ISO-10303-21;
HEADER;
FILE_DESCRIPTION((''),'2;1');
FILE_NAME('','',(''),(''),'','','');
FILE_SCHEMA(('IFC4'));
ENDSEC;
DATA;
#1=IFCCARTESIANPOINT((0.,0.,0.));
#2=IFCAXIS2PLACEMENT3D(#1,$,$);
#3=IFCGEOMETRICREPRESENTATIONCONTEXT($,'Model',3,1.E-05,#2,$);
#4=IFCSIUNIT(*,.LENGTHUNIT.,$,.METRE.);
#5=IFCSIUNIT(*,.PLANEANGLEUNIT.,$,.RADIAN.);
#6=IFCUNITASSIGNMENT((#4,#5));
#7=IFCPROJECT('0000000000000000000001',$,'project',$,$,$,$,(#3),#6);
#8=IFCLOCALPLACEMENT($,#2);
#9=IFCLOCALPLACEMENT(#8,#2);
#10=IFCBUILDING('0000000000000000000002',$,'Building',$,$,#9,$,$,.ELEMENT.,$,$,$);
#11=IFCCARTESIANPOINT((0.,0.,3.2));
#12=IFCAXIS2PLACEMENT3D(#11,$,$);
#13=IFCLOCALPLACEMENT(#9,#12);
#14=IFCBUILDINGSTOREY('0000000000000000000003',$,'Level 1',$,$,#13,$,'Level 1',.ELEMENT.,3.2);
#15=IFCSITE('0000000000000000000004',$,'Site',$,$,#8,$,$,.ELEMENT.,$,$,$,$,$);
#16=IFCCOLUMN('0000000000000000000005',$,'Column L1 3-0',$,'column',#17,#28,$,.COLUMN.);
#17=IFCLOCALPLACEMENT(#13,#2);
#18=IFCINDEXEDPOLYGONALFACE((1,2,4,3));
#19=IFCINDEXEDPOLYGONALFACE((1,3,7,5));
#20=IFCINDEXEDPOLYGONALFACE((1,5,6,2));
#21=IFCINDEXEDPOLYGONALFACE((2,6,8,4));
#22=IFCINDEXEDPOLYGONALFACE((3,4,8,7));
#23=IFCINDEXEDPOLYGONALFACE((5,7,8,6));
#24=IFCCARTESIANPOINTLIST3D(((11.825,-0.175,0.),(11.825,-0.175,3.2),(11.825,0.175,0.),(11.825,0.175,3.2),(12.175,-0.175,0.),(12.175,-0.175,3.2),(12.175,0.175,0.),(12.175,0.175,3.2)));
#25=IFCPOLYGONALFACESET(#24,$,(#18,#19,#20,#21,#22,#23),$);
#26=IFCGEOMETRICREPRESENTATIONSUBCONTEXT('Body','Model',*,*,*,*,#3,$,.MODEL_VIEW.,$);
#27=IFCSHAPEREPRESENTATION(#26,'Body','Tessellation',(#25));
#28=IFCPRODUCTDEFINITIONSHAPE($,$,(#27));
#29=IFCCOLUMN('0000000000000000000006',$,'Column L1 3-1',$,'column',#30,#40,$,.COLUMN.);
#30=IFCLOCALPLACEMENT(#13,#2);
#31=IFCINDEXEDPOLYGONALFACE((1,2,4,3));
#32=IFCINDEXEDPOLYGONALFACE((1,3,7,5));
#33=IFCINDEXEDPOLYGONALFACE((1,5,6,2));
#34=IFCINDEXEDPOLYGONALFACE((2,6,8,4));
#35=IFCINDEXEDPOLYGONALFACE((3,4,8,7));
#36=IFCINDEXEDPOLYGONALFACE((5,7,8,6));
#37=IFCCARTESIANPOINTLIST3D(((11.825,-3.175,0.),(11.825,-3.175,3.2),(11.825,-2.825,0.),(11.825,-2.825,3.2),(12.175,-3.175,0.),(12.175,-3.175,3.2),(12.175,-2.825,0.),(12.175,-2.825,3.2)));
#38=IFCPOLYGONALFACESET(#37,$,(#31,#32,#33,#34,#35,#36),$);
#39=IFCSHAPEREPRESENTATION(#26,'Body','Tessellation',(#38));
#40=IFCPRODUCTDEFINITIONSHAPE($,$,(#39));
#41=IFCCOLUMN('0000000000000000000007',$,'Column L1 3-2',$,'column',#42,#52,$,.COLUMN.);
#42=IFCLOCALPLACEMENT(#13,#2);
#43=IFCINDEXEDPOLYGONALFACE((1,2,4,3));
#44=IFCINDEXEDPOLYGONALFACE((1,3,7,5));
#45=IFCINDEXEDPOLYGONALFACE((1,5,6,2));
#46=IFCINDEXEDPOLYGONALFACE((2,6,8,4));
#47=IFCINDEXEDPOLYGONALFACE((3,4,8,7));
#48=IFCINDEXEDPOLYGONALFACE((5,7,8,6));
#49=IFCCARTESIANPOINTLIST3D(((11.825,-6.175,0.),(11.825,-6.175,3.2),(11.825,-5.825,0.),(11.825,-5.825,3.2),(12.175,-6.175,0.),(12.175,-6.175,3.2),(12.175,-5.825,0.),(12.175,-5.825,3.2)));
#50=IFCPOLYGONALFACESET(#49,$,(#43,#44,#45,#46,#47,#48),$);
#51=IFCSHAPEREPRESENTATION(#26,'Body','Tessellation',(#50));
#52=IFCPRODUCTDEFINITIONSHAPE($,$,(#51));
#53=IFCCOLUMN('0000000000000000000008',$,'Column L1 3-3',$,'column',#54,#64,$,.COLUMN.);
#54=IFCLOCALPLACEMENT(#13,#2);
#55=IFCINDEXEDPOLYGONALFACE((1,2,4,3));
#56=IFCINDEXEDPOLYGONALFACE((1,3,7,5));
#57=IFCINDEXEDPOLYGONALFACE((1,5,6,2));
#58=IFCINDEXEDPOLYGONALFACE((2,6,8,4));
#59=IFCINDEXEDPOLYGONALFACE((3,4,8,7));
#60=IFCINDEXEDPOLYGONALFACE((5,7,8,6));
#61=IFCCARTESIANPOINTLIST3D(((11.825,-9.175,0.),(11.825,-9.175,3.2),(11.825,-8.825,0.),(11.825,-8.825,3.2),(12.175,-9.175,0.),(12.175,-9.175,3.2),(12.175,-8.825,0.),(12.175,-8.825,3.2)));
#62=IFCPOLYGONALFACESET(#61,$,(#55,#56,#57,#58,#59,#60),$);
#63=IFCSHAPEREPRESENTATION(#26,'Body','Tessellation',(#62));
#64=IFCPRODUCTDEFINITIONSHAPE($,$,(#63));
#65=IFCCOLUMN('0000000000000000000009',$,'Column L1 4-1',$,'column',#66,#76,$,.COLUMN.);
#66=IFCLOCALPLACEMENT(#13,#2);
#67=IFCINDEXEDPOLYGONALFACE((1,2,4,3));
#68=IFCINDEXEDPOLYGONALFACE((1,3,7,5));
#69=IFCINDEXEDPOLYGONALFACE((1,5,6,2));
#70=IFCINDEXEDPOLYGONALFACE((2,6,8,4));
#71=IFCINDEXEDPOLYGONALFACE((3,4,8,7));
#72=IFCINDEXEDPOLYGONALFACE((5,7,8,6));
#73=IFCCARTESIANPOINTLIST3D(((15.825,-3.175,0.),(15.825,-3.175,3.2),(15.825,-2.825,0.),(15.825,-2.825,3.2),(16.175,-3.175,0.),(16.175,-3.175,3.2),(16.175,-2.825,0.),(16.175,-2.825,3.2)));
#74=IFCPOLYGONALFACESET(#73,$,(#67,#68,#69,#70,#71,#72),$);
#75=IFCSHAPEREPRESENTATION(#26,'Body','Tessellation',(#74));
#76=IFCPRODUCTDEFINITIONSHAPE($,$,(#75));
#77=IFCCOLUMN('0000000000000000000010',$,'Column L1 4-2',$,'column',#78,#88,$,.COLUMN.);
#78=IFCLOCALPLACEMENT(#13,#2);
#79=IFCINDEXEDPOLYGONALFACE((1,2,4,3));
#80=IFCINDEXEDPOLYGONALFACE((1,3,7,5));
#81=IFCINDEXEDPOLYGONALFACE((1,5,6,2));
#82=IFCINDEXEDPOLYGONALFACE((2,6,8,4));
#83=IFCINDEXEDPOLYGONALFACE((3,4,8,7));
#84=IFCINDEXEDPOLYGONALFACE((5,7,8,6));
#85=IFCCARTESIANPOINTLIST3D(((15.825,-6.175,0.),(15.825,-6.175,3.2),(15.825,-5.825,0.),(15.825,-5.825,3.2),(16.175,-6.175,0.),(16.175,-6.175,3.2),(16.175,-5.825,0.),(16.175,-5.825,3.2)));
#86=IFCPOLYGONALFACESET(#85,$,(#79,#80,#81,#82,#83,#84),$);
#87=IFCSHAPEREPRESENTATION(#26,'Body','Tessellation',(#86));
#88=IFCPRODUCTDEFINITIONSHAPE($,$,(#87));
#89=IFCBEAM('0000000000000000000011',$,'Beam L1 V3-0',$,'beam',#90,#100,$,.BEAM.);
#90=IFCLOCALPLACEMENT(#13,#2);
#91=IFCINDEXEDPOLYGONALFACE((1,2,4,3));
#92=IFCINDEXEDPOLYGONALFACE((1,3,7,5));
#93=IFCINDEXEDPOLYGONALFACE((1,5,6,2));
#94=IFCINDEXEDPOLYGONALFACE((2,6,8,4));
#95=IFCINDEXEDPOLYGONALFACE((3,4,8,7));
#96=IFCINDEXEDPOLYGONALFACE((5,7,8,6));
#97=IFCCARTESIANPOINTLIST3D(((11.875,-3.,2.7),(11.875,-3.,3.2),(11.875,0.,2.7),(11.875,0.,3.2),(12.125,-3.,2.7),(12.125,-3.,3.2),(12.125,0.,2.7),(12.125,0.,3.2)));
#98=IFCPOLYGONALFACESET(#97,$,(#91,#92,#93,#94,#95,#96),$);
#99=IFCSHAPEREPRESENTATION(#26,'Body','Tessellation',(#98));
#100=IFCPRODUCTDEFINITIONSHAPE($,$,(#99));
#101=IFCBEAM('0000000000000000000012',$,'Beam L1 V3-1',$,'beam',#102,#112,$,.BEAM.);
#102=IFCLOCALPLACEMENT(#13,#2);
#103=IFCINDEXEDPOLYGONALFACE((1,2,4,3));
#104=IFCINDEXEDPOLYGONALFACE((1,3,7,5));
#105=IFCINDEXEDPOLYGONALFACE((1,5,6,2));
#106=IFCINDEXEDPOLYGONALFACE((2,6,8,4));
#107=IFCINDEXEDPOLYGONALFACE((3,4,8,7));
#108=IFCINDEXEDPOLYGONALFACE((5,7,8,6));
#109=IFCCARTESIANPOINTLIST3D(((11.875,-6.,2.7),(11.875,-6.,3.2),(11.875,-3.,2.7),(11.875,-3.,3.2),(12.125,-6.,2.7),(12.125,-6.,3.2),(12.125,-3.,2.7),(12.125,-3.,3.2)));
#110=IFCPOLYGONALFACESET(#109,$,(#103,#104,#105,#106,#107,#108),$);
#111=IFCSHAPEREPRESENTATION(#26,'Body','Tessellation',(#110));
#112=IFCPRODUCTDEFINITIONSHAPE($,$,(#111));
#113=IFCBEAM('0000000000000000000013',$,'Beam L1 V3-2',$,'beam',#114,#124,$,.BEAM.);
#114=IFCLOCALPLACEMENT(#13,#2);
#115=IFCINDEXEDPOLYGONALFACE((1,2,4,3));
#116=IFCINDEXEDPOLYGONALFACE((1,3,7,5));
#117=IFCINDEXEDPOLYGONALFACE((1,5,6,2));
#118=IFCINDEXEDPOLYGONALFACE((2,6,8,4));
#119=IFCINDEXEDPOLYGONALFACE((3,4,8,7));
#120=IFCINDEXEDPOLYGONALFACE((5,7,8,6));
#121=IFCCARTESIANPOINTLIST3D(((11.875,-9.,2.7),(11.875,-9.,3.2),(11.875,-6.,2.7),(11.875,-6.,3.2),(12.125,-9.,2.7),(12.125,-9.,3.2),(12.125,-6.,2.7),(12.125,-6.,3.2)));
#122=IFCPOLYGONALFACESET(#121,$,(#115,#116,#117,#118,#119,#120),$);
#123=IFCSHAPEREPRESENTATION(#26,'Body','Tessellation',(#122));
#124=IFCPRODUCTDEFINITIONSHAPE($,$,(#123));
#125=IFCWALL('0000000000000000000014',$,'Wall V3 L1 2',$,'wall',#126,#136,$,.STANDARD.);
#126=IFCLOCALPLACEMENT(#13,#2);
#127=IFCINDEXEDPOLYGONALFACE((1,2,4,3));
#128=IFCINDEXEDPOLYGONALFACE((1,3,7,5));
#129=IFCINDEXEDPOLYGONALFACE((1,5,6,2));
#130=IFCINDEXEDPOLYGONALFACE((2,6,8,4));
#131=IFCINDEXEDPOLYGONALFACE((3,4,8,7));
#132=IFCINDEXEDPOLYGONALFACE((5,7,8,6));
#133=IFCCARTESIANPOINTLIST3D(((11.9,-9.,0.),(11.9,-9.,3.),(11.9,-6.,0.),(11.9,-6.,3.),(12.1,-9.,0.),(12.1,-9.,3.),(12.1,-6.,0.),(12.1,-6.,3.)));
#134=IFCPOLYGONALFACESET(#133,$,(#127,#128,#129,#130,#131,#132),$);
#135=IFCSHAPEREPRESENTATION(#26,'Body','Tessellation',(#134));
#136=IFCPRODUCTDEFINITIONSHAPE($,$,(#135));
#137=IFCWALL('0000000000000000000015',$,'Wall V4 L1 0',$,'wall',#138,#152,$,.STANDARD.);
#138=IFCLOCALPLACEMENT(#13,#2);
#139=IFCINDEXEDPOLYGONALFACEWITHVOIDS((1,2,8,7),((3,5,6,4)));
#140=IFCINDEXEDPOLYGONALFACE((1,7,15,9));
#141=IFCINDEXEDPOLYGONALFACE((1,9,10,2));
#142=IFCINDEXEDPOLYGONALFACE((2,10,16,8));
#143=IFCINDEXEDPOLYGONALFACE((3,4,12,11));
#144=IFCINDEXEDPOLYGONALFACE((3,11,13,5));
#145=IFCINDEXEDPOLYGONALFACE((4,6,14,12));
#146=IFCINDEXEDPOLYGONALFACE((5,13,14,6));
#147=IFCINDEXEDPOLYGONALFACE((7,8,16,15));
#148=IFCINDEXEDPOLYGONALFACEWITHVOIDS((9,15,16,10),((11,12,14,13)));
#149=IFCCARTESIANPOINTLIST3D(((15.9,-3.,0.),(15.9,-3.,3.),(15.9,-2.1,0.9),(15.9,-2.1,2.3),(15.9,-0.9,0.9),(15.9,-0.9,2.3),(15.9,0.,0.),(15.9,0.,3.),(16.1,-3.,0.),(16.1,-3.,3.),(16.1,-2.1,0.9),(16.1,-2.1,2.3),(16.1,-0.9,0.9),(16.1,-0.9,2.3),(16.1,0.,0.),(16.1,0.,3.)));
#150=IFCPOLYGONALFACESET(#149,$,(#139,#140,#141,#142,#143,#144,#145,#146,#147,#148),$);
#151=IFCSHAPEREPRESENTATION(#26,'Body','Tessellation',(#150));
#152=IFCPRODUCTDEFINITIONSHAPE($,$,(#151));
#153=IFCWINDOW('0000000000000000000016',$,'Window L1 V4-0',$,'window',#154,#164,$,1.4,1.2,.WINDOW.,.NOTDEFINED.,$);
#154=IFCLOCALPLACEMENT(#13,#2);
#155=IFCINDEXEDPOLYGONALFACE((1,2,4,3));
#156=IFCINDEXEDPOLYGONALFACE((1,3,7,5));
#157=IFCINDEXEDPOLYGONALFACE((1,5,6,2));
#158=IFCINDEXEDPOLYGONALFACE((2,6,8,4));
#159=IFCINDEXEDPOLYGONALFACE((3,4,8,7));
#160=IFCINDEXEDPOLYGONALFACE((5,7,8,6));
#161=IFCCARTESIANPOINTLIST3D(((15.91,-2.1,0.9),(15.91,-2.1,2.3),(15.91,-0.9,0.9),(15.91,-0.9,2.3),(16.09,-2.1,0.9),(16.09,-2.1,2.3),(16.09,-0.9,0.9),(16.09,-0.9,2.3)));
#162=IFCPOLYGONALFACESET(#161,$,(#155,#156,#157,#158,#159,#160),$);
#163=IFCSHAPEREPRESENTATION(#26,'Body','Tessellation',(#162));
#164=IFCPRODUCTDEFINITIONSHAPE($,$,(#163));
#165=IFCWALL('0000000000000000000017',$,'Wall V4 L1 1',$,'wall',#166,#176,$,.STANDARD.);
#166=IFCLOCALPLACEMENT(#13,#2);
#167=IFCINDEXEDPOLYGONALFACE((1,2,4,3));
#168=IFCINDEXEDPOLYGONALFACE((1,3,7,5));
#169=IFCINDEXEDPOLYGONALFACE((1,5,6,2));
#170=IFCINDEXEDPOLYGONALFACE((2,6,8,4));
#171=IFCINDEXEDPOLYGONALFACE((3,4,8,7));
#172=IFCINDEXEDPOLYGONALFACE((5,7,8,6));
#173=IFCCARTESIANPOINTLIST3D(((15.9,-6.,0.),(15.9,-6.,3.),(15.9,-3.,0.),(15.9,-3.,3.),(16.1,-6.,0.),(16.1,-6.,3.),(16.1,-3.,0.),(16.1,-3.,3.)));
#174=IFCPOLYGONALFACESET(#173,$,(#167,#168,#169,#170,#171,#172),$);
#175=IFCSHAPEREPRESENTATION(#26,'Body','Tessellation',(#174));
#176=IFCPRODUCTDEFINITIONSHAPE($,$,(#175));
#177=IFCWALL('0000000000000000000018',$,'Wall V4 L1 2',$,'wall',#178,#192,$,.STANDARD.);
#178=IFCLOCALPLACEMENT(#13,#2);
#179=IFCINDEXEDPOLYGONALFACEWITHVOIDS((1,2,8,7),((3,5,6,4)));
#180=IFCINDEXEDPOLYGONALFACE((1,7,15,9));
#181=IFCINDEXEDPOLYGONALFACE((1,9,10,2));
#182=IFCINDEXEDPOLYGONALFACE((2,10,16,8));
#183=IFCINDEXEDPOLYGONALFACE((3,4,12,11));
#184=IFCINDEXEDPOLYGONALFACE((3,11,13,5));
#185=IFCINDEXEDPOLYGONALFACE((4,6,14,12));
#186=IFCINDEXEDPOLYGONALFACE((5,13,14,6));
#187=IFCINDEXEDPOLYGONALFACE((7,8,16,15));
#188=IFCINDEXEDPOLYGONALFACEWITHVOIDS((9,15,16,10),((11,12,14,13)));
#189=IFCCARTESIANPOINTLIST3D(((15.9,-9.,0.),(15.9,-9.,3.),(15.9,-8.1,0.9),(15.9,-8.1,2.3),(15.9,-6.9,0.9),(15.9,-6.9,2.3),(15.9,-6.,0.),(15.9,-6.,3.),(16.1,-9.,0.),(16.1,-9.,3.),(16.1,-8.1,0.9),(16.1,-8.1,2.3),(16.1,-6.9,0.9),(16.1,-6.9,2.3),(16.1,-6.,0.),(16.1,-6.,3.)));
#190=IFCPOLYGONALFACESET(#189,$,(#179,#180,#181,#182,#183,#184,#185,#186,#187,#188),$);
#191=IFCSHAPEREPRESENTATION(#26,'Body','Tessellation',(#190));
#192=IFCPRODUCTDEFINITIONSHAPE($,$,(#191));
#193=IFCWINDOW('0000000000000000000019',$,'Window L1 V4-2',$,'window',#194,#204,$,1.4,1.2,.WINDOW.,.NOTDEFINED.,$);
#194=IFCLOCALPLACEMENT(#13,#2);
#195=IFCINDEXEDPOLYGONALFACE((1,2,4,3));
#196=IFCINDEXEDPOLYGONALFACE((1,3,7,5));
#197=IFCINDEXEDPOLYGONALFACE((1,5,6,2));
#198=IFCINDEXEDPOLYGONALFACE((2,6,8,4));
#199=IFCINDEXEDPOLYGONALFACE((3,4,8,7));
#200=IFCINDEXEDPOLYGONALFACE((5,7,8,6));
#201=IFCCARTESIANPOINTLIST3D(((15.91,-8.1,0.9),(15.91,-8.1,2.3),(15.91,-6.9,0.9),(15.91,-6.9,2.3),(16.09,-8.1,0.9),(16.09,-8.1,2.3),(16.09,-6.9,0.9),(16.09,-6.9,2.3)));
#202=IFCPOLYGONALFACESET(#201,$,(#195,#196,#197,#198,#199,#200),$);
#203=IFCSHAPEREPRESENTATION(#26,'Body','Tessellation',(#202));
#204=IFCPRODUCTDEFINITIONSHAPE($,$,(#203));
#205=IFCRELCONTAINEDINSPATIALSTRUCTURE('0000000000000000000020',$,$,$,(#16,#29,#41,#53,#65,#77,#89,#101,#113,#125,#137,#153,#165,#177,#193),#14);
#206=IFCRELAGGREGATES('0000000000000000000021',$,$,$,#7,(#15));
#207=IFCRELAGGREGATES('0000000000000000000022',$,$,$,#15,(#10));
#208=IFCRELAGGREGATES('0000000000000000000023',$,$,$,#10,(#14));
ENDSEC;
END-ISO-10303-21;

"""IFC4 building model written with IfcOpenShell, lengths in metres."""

from ifc_helpers import new_model, si_unit, frame, frame_2d, origin, origin_2d, place, context, subcontext, project, spatial, rectangle, extrude, element, fill, save


model = new_model("IFC4")

# Units and contexts
model_context = context("Model", 3, precision=1e-05, world=origin())
body_context = subcontext(model_context, "Body", "Model", "MODEL_VIEW")
ifc_project = project(units=[si_unit("LENGTHUNIT", "METRE"), si_unit("PLANEANGLEUNIT", "RADIAN")], contexts=[model_context])

# Site, building, storey
site_placement = place(None, origin())
site = spatial("IfcSite", under=ifc_project, at=site_placement, Name="Site", CompositionType="ELEMENT")
building_placement = place(site_placement, origin())
building = spatial("IfcBuilding", under=site, at=building_placement, Name="Building", CompositionType="ELEMENT")
storey_placement = place(building_placement, frame((0.0, 0.0, 3.2)))
storey = spatial("IfcBuildingStorey", under=building, at=storey_placement, Name="Level 1", LongName="Level 1", CompositionType="ELEMENT", Elevation=3.2)

# Columns
for number, where, name in (
    (1, (12.0, 0.0, 0.0), "Column L1 3-0"),
    (2, (12.0, -3.0, 0.0), "Column L1 3-1"),
    (3, (12.0, -6.0, 0.0), "Column L1 3-2"),
    (4, (12.0, -9.0, 0.0), "Column L1 3-3"),
    (5, (16.0, -3.0, 0.0), "Column L1 4-1"),
    (6, (16.0, -6.0, 0.0), "Column L1 4-2"),
):
    element("IfcColumn", number, at=place(storey_placement, frame(where)), inside=storey, Name=name, ObjectType="column", PredefinedType="COLUMN", context=body_context, shape_type="SweptSolid", body=[
        extrude(rectangle(XDim=0.35, YDim=0.35, at=origin_2d()), origin(), (0.0, 0.0, 1.0), 3.2),
    ])

# Beams
for number, where, z_axis, x_axis, name in (
    (7, (12.0, 0.0, 2.95), (0.0, -1.0, 0.0), (0.0, 0.0, 1.0), "Beam L1 V3-0"),
    (8, (12.0, -3.0, 2.95), (0.0, -1.0, 0.0), (0.0, 0.0, 1.0), "Beam L1 V3-1"),
    (9, (12.0, -6.0, 2.95), (0.0, -1.0, 0.0), (0.0, 0.0, 1.0), "Beam L1 V3-2"),
):
    element("IfcBeam", number, at=place(storey_placement, frame(where, z_axis=z_axis, x_axis=x_axis)), inside=storey, Name=name, ObjectType="beam", PredefinedType="BEAM", context=body_context, shape_type="SweptSolid", body=[
        extrude(rectangle(XDim=0.5, YDim=0.25, at=origin_2d()), origin(), (0.0, 0.0, 1.0), 3.0),
    ])

# Wall
wall_1_placement = place(storey_placement, frame((12.0, -6.0, 0.0), z_axis=(0.0, 0.0, 1.0), x_axis=(0.0, -1.0, 0.0)))
element("IfcWall", 10, at=wall_1_placement, inside=storey, Name="Wall V3 L1 2", ObjectType="wall", PredefinedType="STANDARD", context=body_context, shape_type="SweptSolid", body=[
    extrude(rectangle(XDim=3.0, YDim=0.2, at=frame_2d((1.5, 0.0))), origin(), (0.0, 0.0, 1.0), 3.0),
])

# Wall, opening, window
wall_2_placement = place(storey_placement, frame((16.0, 0.0, 0.0), z_axis=(0.0, 0.0, 1.0), x_axis=(0.0, -1.0, 0.0)))
wall_2 = element("IfcWall", 11, at=wall_2_placement, inside=storey, Name="Wall V4 L1 0", ObjectType="wall", PredefinedType="STANDARD", context=body_context, shape_type="SweptSolid", body=[
    extrude(rectangle(XDim=3.0, YDim=0.2, at=frame_2d((1.5, 0.0))), origin(), (0.0, 0.0, 1.0), 3.0),
])
opening_1_placement = place(storey_placement, frame((16.0, -1.5, 0.9), z_axis=(0.0, 0.0, 1.0), x_axis=(0.0, -1.0, 0.0)))
opening_1 = element("IfcOpeningElement", 12, at=opening_1_placement, cuts=wall_2, ObjectType="Opening", PredefinedType="OPENING", context=body_context, shape_type="SweptSolid", body=[
    extrude(rectangle(XDim=1.2, YDim=0.22, at=origin_2d()), origin(), (0.0, 0.0, 1.0), 1.4),
])
window_1_placement = place(storey_placement, frame((16.0, -1.5, 0.9), z_axis=(0.0, 0.0, 1.0), x_axis=(0.0, -1.0, 0.0)))
window_1 = element("IfcWindow", 13, at=window_1_placement, inside=storey, Name="Window L1 V4-0", ObjectType="window", OverallHeight=1.4, OverallWidth=1.2, PartitioningType="NOTDEFINED", PredefinedType="WINDOW", context=body_context, shape_type="SweptSolid", body=[
    extrude(rectangle(XDim=1.2, YDim=0.18, at=origin_2d()), origin(), (0.0, 0.0, 1.0), 1.4),
])
fill(opening_1, window_1)

# Wall
wall_3_placement = place(storey_placement, frame((16.0, -3.0, 0.0), z_axis=(0.0, 0.0, 1.0), x_axis=(0.0, -1.0, 0.0)))
element("IfcWall", 14, at=wall_3_placement, inside=storey, Name="Wall V4 L1 1", ObjectType="wall", PredefinedType="STANDARD", context=body_context, shape_type="SweptSolid", body=[
    extrude(rectangle(XDim=3.0, YDim=0.2, at=frame_2d((1.5, 0.0))), origin(), (0.0, 0.0, 1.0), 3.0),
])

# Wall, opening, window
wall_4_placement = place(storey_placement, frame((16.0, -6.0, 0.0), z_axis=(0.0, 0.0, 1.0), x_axis=(0.0, -1.0, 0.0)))
wall_4 = element("IfcWall", 15, at=wall_4_placement, inside=storey, Name="Wall V4 L1 2", ObjectType="wall", PredefinedType="STANDARD", context=body_context, shape_type="SweptSolid", body=[
    extrude(rectangle(XDim=3.0, YDim=0.2, at=frame_2d((1.5, 0.0))), origin(), (0.0, 0.0, 1.0), 3.0),
])
opening_2_placement = place(storey_placement, frame((16.0, -7.5, 0.9), z_axis=(0.0, 0.0, 1.0), x_axis=(0.0, -1.0, 0.0)))
opening_2 = element("IfcOpeningElement", 16, at=opening_2_placement, cuts=wall_4, ObjectType="Opening", PredefinedType="OPENING", context=body_context, shape_type="SweptSolid", body=[
    extrude(rectangle(XDim=1.2, YDim=0.22, at=origin_2d()), origin(), (0.0, 0.0, 1.0), 1.4),
])
window_2_placement = place(storey_placement, frame((16.0, -7.5, 0.9), z_axis=(0.0, 0.0, 1.0), x_axis=(0.0, -1.0, 0.0)))
window_2 = element("IfcWindow", 17, at=window_2_placement, inside=storey, Name="Window L1 V4-2", ObjectType="window", OverallHeight=1.4, OverallWidth=1.2, PartitioningType="NOTDEFINED", PredefinedType="WINDOW", context=body_context, shape_type="SweptSolid", body=[
    extrude(rectangle(XDim=1.2, YDim=0.18, at=origin_2d()), origin(), (0.0, 0.0, 1.0), 1.4),
])
fill(opening_2, window_2)

save(model, "model.ifc")
